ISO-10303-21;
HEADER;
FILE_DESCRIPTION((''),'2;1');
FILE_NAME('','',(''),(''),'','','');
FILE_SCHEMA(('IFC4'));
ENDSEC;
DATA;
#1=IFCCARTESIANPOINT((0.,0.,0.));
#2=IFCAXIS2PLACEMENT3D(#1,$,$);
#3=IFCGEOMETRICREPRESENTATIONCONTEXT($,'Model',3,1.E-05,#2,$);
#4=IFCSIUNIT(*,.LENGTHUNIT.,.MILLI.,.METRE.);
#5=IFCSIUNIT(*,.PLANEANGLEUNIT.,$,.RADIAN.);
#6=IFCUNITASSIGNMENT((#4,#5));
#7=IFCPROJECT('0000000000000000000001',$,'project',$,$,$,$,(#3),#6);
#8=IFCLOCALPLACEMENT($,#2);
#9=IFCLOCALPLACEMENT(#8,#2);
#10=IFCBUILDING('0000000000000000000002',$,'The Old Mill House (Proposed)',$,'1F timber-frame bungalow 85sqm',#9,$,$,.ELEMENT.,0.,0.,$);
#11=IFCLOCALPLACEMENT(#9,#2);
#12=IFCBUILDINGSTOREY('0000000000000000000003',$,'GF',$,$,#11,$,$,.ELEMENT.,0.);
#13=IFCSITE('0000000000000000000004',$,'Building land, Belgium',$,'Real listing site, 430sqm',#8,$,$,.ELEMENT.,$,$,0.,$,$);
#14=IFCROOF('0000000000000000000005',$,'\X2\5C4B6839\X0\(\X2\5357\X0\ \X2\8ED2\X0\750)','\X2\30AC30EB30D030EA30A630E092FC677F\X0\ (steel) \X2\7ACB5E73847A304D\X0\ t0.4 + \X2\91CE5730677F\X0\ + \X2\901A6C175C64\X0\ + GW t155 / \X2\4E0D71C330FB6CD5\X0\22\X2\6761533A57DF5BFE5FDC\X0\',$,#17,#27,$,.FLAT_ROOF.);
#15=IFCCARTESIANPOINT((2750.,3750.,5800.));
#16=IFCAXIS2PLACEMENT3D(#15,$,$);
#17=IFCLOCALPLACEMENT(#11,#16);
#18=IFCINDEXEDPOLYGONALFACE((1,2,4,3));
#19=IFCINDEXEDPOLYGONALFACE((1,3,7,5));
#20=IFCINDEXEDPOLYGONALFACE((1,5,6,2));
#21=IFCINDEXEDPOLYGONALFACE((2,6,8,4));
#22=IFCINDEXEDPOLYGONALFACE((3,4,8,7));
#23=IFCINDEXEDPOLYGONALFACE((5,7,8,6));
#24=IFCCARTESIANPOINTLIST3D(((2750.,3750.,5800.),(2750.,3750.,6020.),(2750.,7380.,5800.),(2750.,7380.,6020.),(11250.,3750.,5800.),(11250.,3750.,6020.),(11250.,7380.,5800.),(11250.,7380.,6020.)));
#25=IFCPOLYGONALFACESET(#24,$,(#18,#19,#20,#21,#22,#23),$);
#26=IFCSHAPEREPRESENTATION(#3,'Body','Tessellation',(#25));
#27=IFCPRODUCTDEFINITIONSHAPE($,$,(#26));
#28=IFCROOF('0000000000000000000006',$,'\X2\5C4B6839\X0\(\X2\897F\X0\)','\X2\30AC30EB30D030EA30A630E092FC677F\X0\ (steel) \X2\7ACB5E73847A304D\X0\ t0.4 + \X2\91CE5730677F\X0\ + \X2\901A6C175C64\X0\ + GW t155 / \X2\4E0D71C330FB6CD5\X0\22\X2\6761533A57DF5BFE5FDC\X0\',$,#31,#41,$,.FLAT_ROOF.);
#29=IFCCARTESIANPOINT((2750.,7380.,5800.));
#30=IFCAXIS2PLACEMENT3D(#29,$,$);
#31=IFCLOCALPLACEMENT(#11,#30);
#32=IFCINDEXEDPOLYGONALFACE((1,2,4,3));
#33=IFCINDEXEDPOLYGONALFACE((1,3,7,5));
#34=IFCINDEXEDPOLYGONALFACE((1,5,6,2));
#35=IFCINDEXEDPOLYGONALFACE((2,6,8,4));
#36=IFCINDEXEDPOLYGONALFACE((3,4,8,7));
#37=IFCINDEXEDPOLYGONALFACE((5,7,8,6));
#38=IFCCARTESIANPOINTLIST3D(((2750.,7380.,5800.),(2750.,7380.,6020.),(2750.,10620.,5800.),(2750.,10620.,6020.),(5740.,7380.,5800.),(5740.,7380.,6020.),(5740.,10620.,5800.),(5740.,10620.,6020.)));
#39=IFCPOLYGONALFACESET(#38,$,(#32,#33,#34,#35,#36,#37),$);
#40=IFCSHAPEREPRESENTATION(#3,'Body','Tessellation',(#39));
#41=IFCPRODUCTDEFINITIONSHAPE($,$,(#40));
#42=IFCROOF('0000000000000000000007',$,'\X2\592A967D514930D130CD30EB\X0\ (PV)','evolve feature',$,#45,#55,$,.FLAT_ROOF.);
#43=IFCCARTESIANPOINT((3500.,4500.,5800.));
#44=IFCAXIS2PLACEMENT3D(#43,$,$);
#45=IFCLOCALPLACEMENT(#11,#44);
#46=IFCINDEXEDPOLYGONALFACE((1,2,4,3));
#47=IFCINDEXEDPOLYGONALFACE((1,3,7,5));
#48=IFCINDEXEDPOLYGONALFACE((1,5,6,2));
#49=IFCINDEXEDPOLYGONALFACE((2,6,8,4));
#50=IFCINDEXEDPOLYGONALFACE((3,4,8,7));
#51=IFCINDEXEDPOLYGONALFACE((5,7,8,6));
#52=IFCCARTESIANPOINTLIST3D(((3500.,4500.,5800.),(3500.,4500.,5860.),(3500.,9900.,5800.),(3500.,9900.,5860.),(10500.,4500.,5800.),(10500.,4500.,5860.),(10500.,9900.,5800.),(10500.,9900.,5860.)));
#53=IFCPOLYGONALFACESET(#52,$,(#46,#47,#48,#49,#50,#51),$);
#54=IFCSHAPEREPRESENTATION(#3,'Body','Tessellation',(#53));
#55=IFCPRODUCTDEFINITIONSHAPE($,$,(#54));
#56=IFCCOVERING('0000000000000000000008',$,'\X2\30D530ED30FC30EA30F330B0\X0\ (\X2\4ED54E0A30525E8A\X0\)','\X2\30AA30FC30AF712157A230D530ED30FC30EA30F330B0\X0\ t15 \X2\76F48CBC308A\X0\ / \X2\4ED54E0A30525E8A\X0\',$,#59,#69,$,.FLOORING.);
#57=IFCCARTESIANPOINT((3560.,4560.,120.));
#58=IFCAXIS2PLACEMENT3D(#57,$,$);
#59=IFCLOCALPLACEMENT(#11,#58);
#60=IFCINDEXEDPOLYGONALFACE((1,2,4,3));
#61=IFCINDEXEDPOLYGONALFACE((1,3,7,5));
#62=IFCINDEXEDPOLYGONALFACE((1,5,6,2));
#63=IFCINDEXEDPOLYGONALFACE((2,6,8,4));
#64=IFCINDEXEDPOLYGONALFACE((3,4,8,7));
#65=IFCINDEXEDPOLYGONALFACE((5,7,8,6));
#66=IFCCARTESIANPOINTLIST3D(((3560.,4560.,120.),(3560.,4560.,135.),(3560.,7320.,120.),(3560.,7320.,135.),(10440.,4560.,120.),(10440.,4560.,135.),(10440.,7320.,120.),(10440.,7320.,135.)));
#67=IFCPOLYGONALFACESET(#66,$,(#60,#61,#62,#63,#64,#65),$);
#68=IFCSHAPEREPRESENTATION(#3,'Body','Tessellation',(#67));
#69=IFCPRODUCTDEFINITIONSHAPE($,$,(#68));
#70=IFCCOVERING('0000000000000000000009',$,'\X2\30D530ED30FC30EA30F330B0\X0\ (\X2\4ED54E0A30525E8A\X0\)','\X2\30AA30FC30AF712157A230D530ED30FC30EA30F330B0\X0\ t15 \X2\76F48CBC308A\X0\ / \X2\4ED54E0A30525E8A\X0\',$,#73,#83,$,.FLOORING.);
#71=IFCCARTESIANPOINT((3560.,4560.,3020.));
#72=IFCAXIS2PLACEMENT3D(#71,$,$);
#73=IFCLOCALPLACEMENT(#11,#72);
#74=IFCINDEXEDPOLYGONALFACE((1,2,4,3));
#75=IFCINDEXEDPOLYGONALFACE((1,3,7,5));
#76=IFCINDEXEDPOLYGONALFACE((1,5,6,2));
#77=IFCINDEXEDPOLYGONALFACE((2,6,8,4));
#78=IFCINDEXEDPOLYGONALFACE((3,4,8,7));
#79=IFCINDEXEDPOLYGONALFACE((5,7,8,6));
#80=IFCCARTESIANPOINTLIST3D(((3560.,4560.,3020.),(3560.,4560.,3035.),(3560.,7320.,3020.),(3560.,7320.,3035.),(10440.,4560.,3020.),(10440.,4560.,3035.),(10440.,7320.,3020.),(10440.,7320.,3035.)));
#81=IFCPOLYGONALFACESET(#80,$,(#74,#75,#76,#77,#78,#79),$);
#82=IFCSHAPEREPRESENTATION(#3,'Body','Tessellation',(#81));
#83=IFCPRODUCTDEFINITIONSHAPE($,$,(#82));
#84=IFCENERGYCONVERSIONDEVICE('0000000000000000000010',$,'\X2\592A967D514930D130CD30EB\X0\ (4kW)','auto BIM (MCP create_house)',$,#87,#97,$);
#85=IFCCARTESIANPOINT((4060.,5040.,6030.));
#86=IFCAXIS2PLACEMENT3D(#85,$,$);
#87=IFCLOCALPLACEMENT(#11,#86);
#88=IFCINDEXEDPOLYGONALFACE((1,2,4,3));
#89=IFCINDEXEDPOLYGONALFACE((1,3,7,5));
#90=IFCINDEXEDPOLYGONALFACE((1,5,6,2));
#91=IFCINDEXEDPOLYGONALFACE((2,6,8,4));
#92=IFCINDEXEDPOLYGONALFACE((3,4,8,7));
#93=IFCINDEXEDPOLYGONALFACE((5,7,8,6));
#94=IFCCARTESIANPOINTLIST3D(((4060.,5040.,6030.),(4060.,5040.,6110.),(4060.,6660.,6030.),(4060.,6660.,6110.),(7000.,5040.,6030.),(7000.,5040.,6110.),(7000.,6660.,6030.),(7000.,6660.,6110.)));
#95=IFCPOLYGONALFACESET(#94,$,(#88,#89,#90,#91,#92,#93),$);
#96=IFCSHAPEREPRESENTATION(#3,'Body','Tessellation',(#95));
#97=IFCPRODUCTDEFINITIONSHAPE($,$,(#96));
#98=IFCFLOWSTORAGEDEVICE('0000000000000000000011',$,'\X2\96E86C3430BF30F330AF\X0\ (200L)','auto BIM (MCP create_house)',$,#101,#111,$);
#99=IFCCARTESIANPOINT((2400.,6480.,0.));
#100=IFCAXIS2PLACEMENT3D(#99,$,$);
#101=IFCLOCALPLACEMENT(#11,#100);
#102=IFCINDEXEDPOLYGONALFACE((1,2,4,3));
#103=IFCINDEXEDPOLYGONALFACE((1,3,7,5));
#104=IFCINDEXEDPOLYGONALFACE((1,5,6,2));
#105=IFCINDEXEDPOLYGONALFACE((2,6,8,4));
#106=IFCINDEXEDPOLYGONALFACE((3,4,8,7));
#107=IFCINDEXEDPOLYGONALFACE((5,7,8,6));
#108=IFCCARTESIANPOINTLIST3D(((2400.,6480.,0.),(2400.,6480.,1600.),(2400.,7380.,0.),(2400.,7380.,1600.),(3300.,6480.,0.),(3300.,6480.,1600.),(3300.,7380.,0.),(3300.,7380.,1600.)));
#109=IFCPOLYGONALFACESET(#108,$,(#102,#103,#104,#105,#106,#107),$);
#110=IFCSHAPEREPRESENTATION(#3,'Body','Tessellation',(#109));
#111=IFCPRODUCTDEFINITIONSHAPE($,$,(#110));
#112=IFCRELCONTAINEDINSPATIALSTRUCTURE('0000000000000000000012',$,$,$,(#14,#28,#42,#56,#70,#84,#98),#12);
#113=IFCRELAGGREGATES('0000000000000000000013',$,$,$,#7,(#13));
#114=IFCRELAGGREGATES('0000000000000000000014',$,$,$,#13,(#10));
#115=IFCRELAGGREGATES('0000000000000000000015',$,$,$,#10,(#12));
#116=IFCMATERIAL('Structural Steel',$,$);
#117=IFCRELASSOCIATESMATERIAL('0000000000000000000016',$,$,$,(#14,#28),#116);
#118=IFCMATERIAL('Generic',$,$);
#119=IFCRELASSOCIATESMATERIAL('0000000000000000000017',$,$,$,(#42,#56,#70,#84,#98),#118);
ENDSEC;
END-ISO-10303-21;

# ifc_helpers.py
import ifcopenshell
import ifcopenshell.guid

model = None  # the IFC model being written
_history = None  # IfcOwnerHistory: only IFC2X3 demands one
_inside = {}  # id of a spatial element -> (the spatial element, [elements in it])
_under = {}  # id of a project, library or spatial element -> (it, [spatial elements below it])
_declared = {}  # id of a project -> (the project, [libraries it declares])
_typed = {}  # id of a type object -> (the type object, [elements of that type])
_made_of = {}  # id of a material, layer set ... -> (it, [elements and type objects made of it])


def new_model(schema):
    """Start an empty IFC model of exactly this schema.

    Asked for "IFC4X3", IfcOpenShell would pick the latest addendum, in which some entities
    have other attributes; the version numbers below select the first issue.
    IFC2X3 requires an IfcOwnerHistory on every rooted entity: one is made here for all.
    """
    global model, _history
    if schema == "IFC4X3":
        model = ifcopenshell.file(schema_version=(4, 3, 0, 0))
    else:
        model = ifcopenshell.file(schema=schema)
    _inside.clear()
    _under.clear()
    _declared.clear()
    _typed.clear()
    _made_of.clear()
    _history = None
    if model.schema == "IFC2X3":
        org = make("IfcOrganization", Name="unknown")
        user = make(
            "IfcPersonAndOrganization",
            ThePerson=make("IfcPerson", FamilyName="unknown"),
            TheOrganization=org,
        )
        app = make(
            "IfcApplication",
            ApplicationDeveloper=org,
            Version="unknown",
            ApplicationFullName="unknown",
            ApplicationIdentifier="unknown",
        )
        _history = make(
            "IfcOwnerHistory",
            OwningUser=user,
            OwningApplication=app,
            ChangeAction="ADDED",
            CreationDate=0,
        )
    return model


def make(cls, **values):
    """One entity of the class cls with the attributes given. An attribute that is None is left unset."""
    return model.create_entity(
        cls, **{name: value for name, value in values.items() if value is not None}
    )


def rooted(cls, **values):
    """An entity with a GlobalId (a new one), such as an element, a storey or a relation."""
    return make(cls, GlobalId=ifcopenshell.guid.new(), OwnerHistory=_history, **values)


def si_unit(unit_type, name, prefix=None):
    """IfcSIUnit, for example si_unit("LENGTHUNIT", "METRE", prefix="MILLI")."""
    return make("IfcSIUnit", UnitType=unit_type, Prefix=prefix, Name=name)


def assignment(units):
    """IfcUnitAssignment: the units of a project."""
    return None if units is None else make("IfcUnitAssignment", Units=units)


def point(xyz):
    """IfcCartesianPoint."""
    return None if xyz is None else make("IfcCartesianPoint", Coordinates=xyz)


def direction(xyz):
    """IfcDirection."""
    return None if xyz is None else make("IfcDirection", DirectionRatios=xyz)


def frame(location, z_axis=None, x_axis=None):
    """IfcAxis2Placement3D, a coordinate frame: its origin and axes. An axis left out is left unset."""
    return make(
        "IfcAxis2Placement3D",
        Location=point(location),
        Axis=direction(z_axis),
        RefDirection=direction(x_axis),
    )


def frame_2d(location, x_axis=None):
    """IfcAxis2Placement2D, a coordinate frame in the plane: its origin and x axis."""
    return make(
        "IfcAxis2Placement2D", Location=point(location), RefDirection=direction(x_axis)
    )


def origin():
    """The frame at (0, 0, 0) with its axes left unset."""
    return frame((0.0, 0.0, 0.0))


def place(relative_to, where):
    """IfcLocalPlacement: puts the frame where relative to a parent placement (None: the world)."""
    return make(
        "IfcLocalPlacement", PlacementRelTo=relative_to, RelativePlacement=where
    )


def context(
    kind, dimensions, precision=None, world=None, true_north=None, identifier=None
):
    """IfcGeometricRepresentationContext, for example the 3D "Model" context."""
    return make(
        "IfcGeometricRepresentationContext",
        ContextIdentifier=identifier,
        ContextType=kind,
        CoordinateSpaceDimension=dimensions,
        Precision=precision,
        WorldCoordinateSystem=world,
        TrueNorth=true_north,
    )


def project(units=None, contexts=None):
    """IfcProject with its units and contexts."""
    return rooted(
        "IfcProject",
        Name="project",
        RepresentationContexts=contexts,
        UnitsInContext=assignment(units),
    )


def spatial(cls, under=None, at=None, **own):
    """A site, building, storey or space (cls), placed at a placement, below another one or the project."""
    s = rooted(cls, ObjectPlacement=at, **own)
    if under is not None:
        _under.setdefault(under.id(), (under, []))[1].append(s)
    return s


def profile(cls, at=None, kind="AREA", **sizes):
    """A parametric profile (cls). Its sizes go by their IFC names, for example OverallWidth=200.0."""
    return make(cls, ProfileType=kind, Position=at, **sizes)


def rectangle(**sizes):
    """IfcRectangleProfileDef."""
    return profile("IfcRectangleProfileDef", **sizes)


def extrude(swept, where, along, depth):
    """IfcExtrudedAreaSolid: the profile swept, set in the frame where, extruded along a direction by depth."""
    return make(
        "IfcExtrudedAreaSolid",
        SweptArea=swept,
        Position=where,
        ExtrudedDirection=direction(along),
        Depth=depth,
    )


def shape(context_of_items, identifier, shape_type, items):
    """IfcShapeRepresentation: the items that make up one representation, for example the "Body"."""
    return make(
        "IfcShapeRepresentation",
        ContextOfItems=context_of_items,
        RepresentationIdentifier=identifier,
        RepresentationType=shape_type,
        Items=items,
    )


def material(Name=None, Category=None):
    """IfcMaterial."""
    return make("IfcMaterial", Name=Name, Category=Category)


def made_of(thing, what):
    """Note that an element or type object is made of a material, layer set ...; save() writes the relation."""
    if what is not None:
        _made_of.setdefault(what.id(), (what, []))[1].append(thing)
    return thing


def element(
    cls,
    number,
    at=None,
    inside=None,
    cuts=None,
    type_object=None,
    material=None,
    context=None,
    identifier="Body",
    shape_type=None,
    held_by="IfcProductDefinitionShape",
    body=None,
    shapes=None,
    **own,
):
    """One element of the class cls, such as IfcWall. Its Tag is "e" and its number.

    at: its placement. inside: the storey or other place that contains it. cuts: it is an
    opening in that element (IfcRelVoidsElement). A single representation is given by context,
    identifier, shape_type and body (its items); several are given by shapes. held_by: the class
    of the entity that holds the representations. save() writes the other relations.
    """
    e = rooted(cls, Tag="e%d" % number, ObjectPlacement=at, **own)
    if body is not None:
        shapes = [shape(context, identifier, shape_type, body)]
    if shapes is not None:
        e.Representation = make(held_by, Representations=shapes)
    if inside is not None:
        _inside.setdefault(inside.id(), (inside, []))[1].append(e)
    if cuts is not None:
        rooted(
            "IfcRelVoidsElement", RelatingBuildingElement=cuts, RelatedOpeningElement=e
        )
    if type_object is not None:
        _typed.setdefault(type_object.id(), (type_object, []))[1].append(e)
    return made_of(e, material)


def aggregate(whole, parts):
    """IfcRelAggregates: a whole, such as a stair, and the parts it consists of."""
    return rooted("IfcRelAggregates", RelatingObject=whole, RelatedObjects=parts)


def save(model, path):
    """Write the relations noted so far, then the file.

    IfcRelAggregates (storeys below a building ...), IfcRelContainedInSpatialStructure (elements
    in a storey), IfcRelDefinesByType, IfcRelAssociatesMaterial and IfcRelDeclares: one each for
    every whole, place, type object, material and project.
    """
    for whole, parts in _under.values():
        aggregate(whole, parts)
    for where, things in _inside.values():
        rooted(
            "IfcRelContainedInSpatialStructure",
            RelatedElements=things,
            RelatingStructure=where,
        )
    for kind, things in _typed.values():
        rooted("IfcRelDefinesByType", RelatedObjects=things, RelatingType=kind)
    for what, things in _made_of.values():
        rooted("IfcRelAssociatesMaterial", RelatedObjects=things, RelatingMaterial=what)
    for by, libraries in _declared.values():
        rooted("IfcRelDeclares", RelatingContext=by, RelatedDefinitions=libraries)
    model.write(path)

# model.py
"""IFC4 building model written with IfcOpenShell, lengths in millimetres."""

from ifc_helpers import new_model, si_unit, frame, frame_2d, origin, place, context, project, spatial, rectangle, extrude, material, element, save


model = new_model("IFC4")

# Units and contexts
model_context = context("Model", 3, precision=1e-05, world=origin())
ifc_project = project(units=[si_unit("LENGTHUNIT", "METRE", prefix="MILLI"), si_unit("PLANEANGLEUNIT", "RADIAN")], contexts=[model_context])

# Site, building, storey
site_placement = place(None, origin())
site = spatial("IfcSite", under=ifc_project, at=site_placement, Name="Building land, Belgium", ObjectType="Real listing site, 430sqm", CompositionType="ELEMENT", RefElevation=0.0)
building_placement = place(site_placement, origin())
building = spatial("IfcBuilding", under=site, at=building_placement, Name="The Old Mill House (Proposed)", ObjectType="1F timber-frame bungalow 85sqm", CompositionType="ELEMENT", ElevationOfRefHeight=0.0, ElevationOfTerrain=0.0)
storey_placement = place(building_placement, origin())
storey = spatial("IfcBuildingStorey", under=building, at=storey_placement, Name="GF", CompositionType="ELEMENT", Elevation=0.0)

# Shared definitions
ifc_material_1 = material(Name="Generic")

# Roofs
ifc_material_2 = material(Name="Structural Steel")
roof_1_placement = place(storey_placement, frame((2750.0, 3750.0, 5800.0)))
element("IfcRoof", 1, at=roof_1_placement, inside=storey, material=ifc_material_2, Name="屋根(南 軒750)", Description="ガルバリウム鋼板 (steel) 立平葺き t0.4 + 野地板 + 通気層 + GW t155 / 不燃・法22条区域対応", PredefinedType="FLAT_ROOF", context=model_context, shape_type="SweptSolid", body=[
    extrude(rectangle(XDim=8500.0, YDim=3630.0, at=frame_2d((4250.0, 1815.0))), frame((2750.0, 3750.0, 5800.0)), (0.0, 0.0, 1.0), 220.0),
])
roof_2_placement = place(storey_placement, frame((2750.0, 7380.0, 5800.0)))
element("IfcRoof", 2, at=roof_2_placement, inside=storey, material=ifc_material_2, Name="屋根(西)", Description="ガルバリウム鋼板 (steel) 立平葺き t0.4 + 野地板 + 通気層 + GW t155 / 不燃・法22条区域対応", PredefinedType="FLAT_ROOF", context=model_context, shape_type="SweptSolid", body=[
    extrude(rectangle(XDim=2990.0, YDim=3240.0, at=frame_2d((1495.0, 1620.0))), frame((2750.0, 7380.0, 5800.0)), (0.0, 0.0, 1.0), 220.0),
])
roof_3_placement = place(storey_placement, frame((3500.0, 4500.0, 5800.0)))
element("IfcRoof", 3, at=roof_3_placement, inside=storey, material=ifc_material_1, Name="太陽光パネル (PV)", Description="evolve feature", PredefinedType="FLAT_ROOF", context=model_context, shape_type="SweptSolid", body=[
    extrude(rectangle(XDim=7000.0, YDim=5400.0, at=frame_2d((3500.0, 2700.0))), frame((3500.0, 4500.0, 5800.0)), (0.0, 0.0, 1.0), 60.0),
])

# Coverings
covering_1_placement = place(storey_placement, frame((3560.0, 4560.0, 120.0)))
element("IfcCovering", 4, at=covering_1_placement, inside=storey, material=ifc_material_1, Name="フローリング (仕上げ床)", Description="オーク無垢フローリング t15 直貼り / 仕上げ床", PredefinedType="FLOORING", context=model_context, shape_type="SweptSolid", body=[
    extrude(rectangle(XDim=6880.0, YDim=2760.0, at=frame_2d((3440.0, 1380.0))), frame((3560.0, 4560.0, 120.0)), (0.0, 0.0, 1.0), 15.0),
])
covering_2_placement = place(storey_placement, frame((3560.0, 4560.0, 3020.0)))
element("IfcCovering", 5, at=covering_2_placement, inside=storey, material=ifc_material_1, Name="フローリング (仕上げ床)", Description="オーク無垢フローリング t15 直貼り / 仕上げ床", PredefinedType="FLOORING", context=model_context, shape_type="SweptSolid", body=[
    extrude(rectangle(XDim=6880.0, YDim=2760.0, at=frame_2d((3440.0, 1380.0))), frame((3560.0, 4560.0, 3020.0)), (0.0, 0.0, 1.0), 15.0),
])

# Energy conversion device
energy_conversion_device_placement = place(storey_placement, frame((4060.0, 5040.0, 6030.0)))
element("IfcEnergyConversionDevice", 6, at=energy_conversion_device_placement, inside=storey, material=ifc_material_1, Name="太陽光パネル (4kW)", Description="auto BIM (MCP create_house)", context=model_context, shape_type="SweptSolid", body=[
    extrude(rectangle(XDim=2940.0, YDim=1620.0, at=frame_2d((1470.0, 810.0))), frame((4060.0, 5040.0, 6030.0)), (0.0, 0.0, 1.0), 80.0),
])

# Flow storage device
flow_storage_device_placement = place(storey_placement, frame((2400.0, 6480.0, 0.0)))
element("IfcFlowStorageDevice", 7, at=flow_storage_device_placement, inside=storey, material=ifc_material_1, Name="雨水タンク (200L)", Description="auto BIM (MCP create_house)", context=model_context, shape_type="SweptSolid", body=[
    extrude(rectangle(XDim=900.0, YDim=900.0, at=frame_2d((450.0, 450.0))), frame((2400.0, 6480.0, 0.0)), (0.0, 0.0, 1.0), 1600.0),
])

save(model, "model.ifc")
